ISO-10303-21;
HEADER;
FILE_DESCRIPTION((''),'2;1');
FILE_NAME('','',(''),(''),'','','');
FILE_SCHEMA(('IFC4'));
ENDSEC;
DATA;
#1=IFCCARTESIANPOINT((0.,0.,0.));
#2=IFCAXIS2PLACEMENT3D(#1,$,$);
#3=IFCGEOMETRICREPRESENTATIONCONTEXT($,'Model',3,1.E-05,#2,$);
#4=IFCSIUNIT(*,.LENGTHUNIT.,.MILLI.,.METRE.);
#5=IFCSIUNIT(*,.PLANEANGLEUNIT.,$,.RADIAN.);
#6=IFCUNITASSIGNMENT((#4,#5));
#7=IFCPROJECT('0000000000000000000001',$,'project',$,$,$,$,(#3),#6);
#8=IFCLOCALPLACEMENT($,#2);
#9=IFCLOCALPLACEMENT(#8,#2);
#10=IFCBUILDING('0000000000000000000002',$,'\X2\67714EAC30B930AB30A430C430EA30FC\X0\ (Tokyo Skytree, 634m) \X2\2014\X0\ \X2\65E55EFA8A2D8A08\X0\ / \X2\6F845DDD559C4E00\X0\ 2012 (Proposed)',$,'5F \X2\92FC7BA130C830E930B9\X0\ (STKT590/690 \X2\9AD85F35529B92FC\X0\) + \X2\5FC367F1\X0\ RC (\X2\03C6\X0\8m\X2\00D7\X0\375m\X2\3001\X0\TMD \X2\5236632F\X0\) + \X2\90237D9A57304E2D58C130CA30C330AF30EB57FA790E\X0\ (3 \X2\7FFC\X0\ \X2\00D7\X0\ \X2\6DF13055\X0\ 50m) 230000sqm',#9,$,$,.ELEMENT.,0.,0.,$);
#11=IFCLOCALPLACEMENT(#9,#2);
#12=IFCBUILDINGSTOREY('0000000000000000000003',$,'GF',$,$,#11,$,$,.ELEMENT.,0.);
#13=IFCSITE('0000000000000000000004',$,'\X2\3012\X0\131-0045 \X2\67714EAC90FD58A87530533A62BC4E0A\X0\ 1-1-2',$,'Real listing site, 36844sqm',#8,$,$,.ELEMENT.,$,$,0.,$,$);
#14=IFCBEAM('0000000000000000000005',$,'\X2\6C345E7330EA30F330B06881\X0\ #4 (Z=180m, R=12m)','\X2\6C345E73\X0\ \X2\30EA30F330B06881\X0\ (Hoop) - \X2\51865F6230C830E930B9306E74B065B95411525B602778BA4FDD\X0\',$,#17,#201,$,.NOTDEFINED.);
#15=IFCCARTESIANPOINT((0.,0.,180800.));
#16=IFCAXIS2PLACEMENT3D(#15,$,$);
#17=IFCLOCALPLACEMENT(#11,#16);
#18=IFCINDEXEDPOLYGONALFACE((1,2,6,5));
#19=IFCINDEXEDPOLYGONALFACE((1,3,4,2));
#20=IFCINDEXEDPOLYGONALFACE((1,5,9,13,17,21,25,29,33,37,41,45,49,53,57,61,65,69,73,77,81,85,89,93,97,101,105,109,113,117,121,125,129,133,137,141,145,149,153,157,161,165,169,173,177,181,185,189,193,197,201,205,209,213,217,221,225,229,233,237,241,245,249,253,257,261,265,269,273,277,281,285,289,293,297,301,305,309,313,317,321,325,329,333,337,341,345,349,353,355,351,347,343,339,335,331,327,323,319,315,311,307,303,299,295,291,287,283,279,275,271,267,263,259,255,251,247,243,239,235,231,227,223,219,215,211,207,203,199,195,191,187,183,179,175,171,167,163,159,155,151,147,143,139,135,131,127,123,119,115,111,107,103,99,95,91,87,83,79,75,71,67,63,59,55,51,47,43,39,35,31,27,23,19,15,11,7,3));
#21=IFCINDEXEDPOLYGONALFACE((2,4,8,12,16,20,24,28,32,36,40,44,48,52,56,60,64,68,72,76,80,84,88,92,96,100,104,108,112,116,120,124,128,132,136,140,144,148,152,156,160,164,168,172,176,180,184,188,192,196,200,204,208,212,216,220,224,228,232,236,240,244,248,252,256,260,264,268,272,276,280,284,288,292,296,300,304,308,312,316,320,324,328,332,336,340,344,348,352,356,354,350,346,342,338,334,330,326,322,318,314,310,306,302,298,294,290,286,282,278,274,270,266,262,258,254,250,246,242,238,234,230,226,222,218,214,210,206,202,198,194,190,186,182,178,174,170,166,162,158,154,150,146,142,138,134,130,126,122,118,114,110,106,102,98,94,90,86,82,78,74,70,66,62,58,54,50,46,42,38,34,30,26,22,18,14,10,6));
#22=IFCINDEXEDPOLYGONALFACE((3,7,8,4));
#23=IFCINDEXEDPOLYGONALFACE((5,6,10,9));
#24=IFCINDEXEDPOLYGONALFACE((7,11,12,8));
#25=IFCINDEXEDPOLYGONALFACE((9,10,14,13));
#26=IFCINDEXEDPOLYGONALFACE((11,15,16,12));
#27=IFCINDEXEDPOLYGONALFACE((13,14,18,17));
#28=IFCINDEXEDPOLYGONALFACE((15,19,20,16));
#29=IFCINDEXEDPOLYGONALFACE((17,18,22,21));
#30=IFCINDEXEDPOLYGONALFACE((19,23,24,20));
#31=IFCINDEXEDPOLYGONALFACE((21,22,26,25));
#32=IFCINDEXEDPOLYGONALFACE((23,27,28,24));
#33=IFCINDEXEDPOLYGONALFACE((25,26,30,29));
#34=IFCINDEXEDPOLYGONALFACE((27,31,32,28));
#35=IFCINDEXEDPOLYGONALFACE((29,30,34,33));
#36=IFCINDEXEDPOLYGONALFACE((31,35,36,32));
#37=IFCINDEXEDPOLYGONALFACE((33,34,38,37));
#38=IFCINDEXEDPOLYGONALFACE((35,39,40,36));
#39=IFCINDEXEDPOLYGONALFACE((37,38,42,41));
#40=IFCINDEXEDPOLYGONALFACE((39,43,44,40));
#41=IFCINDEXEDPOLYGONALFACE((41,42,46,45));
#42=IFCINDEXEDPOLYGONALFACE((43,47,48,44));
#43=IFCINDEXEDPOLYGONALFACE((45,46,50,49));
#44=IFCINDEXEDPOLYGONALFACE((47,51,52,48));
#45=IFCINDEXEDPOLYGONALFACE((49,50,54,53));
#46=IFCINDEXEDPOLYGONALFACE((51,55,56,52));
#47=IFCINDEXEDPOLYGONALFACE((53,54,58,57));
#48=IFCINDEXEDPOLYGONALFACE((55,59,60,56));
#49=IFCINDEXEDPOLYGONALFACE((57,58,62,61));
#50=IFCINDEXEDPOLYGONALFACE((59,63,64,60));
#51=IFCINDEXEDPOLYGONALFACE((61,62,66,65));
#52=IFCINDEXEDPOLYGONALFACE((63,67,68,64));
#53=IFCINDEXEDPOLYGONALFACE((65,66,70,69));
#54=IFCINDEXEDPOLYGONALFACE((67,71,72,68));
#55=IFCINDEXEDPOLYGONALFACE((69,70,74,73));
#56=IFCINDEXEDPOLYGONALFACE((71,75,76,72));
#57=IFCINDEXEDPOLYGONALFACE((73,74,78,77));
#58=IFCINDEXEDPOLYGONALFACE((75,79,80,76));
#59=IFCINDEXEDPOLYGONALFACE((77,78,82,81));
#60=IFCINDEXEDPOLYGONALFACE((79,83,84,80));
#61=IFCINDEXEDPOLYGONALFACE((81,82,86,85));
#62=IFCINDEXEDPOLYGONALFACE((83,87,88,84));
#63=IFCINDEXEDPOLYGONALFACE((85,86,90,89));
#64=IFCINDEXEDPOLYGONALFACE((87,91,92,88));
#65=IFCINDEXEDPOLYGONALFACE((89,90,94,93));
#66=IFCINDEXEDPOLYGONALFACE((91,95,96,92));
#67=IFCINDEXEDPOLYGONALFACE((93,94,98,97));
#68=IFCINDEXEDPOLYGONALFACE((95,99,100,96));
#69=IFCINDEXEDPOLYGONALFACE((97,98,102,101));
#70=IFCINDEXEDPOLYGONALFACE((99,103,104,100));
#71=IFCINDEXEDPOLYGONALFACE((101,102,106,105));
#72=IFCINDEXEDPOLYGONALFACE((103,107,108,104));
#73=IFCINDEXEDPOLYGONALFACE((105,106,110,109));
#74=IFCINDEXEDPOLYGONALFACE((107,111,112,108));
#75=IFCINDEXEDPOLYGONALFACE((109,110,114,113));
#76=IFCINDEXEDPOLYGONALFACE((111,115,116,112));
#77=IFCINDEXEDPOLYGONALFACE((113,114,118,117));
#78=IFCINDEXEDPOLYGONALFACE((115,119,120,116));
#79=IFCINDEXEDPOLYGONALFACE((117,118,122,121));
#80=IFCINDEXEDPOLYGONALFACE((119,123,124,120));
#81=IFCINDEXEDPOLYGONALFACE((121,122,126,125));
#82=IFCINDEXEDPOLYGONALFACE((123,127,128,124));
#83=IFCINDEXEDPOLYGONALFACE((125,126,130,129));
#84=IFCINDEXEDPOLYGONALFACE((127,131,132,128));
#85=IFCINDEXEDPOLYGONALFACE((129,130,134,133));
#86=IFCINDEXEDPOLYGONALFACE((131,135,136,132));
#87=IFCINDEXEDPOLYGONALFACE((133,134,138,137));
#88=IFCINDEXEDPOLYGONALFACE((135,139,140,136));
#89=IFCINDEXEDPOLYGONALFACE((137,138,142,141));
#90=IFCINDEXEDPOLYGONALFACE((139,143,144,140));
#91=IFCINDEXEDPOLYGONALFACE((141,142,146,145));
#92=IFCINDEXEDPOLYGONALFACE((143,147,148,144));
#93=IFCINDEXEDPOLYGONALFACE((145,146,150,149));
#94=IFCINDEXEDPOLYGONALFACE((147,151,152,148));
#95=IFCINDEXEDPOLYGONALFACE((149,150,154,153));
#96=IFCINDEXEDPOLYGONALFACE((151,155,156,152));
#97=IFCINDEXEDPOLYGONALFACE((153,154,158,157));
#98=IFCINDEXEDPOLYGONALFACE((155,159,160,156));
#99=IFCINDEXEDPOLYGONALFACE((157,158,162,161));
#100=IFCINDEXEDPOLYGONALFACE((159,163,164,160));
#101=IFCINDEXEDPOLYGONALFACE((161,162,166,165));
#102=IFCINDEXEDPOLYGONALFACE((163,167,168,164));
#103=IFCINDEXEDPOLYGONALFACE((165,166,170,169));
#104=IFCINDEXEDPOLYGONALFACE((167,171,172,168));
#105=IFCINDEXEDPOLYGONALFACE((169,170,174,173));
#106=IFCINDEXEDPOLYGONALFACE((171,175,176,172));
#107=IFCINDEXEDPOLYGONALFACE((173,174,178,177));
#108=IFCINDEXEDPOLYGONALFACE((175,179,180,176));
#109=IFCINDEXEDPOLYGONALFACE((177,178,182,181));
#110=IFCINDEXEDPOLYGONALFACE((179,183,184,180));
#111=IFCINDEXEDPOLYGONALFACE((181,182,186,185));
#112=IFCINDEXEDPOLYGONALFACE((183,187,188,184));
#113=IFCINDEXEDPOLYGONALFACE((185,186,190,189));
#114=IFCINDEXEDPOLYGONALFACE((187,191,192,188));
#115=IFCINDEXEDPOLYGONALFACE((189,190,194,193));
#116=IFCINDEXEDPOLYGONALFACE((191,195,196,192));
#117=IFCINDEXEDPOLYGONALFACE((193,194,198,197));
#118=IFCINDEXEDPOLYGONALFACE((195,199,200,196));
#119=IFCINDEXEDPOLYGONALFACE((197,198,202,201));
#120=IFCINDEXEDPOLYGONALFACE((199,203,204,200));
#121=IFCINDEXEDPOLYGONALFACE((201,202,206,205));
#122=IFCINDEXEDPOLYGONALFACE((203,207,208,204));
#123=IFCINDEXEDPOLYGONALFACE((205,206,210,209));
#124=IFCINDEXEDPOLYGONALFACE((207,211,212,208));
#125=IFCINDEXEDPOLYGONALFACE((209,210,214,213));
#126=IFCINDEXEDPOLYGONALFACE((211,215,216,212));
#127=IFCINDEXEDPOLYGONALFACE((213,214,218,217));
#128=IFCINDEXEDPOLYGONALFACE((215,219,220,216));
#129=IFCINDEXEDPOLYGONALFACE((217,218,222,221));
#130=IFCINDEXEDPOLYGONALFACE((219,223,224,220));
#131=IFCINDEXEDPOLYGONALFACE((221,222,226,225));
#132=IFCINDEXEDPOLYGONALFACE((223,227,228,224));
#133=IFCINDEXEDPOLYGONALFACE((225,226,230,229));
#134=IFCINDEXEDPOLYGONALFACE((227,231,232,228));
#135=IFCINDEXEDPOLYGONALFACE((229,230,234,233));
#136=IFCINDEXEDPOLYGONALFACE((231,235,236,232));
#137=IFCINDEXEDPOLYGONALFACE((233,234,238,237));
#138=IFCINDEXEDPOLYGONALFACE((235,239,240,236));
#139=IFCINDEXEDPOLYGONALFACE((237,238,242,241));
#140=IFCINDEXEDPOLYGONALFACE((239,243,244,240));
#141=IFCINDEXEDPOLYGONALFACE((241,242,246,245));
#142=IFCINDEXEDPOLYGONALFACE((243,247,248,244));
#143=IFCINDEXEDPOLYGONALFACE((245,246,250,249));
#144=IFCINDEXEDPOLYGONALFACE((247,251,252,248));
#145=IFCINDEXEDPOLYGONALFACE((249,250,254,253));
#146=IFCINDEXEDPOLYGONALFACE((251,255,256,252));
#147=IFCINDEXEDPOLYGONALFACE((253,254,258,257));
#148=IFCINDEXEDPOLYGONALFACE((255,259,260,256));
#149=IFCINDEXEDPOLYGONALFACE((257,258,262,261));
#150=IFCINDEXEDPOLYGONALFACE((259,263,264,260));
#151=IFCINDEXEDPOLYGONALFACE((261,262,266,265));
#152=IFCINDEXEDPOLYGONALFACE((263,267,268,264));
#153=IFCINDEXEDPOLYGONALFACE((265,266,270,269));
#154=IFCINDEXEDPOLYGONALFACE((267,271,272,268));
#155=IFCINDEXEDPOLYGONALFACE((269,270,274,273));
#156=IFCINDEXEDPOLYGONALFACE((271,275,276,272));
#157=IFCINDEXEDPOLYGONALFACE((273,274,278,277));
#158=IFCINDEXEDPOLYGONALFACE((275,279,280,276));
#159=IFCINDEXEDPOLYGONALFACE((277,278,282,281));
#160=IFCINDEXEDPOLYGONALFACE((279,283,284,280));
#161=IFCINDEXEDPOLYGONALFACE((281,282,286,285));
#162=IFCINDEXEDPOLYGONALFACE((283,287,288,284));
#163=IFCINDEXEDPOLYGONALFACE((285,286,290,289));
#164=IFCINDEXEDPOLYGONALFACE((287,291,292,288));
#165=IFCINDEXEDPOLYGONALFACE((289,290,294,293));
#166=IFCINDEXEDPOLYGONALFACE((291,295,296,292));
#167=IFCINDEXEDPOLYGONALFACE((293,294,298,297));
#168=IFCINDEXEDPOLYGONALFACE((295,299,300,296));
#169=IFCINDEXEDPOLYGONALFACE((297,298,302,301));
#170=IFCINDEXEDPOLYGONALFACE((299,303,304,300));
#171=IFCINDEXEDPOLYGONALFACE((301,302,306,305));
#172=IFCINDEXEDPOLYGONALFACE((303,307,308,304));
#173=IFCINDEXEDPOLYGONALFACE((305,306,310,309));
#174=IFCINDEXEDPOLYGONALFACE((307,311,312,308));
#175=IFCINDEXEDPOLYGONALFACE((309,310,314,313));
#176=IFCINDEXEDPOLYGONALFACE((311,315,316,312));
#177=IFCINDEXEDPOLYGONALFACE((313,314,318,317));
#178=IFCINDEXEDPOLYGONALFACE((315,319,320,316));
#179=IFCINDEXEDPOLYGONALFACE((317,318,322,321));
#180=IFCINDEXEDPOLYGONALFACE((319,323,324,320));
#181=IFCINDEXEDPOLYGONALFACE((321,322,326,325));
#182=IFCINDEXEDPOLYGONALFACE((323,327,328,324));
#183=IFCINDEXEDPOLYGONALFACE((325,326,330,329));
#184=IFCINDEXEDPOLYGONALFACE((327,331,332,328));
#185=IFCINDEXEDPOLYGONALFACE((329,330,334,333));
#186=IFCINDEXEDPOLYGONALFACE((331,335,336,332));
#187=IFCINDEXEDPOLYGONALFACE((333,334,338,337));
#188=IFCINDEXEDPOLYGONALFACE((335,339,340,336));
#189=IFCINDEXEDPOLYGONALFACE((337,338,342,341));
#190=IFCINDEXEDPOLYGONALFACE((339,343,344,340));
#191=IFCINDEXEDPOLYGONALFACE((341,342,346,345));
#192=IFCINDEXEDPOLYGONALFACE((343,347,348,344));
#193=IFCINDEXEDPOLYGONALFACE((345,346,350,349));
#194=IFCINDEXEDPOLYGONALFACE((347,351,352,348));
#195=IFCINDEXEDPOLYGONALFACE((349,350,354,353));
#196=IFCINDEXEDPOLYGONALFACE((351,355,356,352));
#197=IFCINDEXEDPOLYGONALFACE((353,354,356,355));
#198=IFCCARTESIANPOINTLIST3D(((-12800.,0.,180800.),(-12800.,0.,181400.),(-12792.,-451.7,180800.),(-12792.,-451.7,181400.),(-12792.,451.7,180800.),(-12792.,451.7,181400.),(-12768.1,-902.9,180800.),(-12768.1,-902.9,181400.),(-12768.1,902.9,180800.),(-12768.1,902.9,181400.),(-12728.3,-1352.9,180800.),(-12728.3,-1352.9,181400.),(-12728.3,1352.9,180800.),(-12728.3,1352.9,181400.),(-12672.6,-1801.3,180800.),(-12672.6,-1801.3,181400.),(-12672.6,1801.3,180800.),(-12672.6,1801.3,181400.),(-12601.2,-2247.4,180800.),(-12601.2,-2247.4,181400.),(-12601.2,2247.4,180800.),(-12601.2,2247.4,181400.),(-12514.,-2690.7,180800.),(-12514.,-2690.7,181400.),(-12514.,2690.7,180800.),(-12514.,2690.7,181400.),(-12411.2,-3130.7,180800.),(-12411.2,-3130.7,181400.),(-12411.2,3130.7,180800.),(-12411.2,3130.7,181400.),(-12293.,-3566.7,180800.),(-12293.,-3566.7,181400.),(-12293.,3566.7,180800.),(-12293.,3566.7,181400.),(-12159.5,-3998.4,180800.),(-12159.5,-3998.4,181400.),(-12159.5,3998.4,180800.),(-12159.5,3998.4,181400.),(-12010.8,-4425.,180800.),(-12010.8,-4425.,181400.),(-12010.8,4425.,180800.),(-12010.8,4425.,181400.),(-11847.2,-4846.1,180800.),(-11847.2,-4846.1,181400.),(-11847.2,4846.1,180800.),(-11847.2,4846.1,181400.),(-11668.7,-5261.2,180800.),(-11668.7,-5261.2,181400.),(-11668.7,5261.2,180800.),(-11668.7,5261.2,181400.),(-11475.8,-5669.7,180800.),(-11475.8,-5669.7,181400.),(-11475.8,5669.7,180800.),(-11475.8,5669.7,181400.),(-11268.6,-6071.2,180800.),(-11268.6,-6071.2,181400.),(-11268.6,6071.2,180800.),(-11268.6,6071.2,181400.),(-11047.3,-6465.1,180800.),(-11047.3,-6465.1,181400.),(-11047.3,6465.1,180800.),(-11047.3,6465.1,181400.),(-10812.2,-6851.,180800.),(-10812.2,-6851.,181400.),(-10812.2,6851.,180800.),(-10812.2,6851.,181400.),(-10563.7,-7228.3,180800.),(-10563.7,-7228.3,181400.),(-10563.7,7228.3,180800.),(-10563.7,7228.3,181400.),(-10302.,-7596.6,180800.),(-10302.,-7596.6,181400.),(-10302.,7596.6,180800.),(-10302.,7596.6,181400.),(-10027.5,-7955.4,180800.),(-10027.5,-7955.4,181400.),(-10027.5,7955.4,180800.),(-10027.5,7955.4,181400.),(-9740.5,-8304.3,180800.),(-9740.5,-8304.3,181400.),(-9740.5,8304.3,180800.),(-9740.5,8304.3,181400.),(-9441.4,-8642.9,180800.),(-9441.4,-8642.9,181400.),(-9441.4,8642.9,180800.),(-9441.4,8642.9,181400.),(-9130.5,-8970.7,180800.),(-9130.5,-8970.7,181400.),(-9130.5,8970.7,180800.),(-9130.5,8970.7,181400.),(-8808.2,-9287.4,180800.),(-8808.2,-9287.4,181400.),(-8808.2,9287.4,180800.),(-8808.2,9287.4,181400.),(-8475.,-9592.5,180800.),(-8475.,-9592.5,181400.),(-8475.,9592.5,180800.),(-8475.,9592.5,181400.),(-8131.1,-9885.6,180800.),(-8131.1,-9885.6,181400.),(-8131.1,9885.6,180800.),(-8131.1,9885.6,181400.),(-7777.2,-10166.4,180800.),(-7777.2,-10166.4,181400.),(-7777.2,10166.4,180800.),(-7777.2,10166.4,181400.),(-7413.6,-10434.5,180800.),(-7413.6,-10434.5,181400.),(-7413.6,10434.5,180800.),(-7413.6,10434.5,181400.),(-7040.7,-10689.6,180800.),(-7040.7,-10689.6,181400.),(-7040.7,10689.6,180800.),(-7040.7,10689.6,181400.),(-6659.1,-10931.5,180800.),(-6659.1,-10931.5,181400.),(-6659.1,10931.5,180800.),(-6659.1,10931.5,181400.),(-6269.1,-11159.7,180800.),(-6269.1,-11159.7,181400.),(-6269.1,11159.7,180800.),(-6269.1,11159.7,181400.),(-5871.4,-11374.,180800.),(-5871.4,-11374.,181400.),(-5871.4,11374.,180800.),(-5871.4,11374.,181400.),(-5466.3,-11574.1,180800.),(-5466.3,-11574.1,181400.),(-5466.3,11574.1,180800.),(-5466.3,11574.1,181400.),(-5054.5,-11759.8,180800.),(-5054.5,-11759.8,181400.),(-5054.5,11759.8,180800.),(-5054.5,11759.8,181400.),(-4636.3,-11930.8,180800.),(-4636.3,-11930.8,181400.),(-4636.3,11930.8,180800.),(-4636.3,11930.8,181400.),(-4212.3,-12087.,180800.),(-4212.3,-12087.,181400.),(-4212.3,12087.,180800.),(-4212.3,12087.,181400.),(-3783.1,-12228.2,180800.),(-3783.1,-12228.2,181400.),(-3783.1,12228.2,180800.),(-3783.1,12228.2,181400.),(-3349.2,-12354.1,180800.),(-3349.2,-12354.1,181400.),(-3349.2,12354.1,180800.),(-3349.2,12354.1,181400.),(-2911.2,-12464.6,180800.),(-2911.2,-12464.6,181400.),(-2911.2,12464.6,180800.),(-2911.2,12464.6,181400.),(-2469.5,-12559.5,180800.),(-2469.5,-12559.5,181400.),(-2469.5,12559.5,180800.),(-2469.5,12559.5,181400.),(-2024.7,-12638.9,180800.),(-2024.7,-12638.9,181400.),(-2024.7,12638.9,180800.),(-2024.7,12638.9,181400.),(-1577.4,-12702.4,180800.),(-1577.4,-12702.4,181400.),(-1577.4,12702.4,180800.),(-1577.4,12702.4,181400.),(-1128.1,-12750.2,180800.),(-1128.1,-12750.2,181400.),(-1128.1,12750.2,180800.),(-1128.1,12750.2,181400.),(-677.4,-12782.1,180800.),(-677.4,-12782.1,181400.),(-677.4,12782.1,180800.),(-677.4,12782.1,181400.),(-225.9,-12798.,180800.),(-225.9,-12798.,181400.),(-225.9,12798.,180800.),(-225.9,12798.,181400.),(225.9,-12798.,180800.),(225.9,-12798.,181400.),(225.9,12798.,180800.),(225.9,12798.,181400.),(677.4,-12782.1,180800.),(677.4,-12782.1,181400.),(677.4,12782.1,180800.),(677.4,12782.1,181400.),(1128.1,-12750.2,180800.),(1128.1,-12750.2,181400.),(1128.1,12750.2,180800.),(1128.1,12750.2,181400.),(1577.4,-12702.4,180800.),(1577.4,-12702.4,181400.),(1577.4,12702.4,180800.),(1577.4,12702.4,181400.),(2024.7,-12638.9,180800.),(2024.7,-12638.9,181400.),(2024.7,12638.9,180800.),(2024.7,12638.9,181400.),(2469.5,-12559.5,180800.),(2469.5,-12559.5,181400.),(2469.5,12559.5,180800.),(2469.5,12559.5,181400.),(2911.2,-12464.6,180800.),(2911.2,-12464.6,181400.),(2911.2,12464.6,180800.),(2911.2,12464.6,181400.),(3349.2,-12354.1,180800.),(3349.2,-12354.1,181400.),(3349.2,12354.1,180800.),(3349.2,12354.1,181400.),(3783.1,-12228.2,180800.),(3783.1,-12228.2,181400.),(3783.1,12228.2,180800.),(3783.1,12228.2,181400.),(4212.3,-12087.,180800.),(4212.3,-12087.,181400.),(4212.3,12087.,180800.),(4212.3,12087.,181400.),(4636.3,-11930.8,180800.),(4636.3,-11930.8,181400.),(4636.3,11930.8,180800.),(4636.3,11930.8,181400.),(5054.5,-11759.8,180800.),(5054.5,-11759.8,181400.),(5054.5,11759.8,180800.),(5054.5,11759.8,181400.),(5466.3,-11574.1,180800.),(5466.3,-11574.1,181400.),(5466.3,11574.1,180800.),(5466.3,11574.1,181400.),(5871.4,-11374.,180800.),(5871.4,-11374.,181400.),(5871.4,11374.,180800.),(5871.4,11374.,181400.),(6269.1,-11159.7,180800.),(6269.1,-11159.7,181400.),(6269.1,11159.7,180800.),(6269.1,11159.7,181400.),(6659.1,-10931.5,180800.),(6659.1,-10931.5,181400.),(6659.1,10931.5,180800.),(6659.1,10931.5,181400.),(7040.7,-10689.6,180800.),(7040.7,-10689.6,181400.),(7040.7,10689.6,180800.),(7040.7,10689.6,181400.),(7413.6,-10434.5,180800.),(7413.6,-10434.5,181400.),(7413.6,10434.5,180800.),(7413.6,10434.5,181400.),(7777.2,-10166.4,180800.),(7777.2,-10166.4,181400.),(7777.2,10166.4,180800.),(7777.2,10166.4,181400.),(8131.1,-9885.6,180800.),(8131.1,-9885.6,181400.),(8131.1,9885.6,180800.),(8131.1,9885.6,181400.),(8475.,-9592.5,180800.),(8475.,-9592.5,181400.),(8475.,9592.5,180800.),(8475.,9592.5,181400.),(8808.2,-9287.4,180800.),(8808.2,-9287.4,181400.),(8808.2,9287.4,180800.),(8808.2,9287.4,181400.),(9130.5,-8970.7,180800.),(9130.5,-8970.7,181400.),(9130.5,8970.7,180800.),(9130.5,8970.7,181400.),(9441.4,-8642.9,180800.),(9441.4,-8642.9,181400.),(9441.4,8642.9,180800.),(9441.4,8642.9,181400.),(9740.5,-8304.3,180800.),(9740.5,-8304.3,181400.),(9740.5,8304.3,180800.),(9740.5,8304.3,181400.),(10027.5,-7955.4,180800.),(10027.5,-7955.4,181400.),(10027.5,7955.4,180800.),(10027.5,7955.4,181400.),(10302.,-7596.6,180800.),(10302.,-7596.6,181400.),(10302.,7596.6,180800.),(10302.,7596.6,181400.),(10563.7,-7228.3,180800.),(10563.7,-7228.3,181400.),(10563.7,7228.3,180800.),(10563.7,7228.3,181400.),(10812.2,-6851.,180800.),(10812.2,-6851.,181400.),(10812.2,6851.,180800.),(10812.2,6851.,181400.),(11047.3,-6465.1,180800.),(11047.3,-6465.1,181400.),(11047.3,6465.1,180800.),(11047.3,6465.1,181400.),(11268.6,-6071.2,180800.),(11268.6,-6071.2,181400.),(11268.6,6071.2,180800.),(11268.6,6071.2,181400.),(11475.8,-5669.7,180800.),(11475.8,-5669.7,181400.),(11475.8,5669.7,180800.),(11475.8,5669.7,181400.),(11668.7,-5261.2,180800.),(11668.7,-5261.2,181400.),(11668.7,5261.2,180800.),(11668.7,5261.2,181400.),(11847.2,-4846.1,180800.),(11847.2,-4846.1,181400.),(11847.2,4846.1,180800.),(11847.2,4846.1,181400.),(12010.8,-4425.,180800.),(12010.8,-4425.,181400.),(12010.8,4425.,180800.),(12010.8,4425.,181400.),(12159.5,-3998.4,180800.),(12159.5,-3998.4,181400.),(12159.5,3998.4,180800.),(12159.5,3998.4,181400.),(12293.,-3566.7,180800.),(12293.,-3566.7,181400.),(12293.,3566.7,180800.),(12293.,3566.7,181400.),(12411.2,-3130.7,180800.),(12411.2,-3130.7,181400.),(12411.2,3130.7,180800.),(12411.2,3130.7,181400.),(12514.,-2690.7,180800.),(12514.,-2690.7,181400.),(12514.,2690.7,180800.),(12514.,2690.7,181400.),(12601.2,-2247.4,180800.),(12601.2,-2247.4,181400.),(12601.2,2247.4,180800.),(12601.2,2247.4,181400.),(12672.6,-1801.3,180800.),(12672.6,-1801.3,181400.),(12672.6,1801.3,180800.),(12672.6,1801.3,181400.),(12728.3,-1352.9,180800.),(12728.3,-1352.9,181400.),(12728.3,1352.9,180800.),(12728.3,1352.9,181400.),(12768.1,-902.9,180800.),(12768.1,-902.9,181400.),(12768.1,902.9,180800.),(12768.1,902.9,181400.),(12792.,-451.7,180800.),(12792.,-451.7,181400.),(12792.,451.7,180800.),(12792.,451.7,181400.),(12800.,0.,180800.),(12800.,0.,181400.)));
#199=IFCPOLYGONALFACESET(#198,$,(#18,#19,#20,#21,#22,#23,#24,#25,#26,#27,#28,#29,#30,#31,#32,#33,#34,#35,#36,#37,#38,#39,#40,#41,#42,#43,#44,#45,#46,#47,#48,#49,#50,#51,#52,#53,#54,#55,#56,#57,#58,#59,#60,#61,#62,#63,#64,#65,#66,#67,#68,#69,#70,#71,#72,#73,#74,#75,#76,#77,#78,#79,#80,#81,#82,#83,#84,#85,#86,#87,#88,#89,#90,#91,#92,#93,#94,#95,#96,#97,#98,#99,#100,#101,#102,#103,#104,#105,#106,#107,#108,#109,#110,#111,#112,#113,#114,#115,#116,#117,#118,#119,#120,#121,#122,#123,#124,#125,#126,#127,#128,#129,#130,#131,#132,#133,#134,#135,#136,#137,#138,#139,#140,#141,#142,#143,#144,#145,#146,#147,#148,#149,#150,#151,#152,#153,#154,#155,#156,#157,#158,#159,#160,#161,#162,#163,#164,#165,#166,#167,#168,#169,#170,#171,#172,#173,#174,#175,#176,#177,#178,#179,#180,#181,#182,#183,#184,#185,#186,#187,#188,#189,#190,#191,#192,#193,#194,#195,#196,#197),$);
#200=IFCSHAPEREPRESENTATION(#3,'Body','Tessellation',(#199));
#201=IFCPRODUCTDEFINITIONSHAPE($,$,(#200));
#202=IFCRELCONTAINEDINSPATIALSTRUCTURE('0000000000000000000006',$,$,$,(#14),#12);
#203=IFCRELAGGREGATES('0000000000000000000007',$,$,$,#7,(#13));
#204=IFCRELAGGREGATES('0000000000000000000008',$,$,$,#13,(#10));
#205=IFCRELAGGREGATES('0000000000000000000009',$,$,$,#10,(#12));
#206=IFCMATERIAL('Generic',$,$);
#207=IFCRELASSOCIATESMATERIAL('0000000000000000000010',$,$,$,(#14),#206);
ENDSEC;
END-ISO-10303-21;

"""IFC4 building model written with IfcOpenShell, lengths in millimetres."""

from ifc_helpers import new_model, si_unit, frame, origin, origin_2d, place, context, project, spatial, circle, extrude, material, element, save


model = new_model("IFC4")

# Units and contexts
model_context = context("Model", 3, precision=1e-05, world=origin())
ifc_project = project(units=[si_unit("LENGTHUNIT", "METRE", prefix="MILLI"), si_unit("PLANEANGLEUNIT", "RADIAN")], contexts=[model_context])

# Site, building, storey
site_placement = place(None, origin())
site = spatial("IfcSite", under=ifc_project, at=site_placement, Name="〒131-0045 東京都墨田区押上 1-1-2", ObjectType="Real listing site, 36844sqm", CompositionType="ELEMENT", RefElevation=0.0)
building_placement = place(site_placement, origin())
building = spatial("IfcBuilding", under=site, at=building_placement, Name="東京スカイツリー (Tokyo Skytree, 634m) — 日建設計 / 澄川喜一 2012 (Proposed)", ObjectType="5F 鋼管トラス (STKT590/690 高張力鋼) + 心柱 RC (φ8m×375m、TMD 制振) + 連続地中壁ナックル基礎 (3 翼 × 深さ 50m) 230000sqm", CompositionType="ELEMENT", ElevationOfRefHeight=0.0, ElevationOfTerrain=0.0)
storey_placement = place(building_placement, origin())
storey = spatial("IfcBuildingStorey", under=building, at=storey_placement, Name="GF", CompositionType="ELEMENT", Elevation=0.0)

# Shared definitions
ifc_material_1 = material(Name="Generic")

# Beam
beam_1_placement = place(storey_placement, frame((0.0, 0.0, 180800.0)))
element("IfcBeam", 1, at=beam_1_placement, inside=storey, material=ifc_material_1, Name="水平リング梁 #4 (Z=180m, R=12m)", Description="水平 リング梁 (Hoop) - 円形トラスの環方向剛性確保", PredefinedType="NOTDEFINED", context=model_context, shape_type="SweptSolid", body=[
    extrude(circle(Radius=12800.0, at=origin_2d()), frame((0.0, 0.0, 180800.0)), (0.0, 0.0, 1.0), 600.0),
])

save(model, "model.ifc")
